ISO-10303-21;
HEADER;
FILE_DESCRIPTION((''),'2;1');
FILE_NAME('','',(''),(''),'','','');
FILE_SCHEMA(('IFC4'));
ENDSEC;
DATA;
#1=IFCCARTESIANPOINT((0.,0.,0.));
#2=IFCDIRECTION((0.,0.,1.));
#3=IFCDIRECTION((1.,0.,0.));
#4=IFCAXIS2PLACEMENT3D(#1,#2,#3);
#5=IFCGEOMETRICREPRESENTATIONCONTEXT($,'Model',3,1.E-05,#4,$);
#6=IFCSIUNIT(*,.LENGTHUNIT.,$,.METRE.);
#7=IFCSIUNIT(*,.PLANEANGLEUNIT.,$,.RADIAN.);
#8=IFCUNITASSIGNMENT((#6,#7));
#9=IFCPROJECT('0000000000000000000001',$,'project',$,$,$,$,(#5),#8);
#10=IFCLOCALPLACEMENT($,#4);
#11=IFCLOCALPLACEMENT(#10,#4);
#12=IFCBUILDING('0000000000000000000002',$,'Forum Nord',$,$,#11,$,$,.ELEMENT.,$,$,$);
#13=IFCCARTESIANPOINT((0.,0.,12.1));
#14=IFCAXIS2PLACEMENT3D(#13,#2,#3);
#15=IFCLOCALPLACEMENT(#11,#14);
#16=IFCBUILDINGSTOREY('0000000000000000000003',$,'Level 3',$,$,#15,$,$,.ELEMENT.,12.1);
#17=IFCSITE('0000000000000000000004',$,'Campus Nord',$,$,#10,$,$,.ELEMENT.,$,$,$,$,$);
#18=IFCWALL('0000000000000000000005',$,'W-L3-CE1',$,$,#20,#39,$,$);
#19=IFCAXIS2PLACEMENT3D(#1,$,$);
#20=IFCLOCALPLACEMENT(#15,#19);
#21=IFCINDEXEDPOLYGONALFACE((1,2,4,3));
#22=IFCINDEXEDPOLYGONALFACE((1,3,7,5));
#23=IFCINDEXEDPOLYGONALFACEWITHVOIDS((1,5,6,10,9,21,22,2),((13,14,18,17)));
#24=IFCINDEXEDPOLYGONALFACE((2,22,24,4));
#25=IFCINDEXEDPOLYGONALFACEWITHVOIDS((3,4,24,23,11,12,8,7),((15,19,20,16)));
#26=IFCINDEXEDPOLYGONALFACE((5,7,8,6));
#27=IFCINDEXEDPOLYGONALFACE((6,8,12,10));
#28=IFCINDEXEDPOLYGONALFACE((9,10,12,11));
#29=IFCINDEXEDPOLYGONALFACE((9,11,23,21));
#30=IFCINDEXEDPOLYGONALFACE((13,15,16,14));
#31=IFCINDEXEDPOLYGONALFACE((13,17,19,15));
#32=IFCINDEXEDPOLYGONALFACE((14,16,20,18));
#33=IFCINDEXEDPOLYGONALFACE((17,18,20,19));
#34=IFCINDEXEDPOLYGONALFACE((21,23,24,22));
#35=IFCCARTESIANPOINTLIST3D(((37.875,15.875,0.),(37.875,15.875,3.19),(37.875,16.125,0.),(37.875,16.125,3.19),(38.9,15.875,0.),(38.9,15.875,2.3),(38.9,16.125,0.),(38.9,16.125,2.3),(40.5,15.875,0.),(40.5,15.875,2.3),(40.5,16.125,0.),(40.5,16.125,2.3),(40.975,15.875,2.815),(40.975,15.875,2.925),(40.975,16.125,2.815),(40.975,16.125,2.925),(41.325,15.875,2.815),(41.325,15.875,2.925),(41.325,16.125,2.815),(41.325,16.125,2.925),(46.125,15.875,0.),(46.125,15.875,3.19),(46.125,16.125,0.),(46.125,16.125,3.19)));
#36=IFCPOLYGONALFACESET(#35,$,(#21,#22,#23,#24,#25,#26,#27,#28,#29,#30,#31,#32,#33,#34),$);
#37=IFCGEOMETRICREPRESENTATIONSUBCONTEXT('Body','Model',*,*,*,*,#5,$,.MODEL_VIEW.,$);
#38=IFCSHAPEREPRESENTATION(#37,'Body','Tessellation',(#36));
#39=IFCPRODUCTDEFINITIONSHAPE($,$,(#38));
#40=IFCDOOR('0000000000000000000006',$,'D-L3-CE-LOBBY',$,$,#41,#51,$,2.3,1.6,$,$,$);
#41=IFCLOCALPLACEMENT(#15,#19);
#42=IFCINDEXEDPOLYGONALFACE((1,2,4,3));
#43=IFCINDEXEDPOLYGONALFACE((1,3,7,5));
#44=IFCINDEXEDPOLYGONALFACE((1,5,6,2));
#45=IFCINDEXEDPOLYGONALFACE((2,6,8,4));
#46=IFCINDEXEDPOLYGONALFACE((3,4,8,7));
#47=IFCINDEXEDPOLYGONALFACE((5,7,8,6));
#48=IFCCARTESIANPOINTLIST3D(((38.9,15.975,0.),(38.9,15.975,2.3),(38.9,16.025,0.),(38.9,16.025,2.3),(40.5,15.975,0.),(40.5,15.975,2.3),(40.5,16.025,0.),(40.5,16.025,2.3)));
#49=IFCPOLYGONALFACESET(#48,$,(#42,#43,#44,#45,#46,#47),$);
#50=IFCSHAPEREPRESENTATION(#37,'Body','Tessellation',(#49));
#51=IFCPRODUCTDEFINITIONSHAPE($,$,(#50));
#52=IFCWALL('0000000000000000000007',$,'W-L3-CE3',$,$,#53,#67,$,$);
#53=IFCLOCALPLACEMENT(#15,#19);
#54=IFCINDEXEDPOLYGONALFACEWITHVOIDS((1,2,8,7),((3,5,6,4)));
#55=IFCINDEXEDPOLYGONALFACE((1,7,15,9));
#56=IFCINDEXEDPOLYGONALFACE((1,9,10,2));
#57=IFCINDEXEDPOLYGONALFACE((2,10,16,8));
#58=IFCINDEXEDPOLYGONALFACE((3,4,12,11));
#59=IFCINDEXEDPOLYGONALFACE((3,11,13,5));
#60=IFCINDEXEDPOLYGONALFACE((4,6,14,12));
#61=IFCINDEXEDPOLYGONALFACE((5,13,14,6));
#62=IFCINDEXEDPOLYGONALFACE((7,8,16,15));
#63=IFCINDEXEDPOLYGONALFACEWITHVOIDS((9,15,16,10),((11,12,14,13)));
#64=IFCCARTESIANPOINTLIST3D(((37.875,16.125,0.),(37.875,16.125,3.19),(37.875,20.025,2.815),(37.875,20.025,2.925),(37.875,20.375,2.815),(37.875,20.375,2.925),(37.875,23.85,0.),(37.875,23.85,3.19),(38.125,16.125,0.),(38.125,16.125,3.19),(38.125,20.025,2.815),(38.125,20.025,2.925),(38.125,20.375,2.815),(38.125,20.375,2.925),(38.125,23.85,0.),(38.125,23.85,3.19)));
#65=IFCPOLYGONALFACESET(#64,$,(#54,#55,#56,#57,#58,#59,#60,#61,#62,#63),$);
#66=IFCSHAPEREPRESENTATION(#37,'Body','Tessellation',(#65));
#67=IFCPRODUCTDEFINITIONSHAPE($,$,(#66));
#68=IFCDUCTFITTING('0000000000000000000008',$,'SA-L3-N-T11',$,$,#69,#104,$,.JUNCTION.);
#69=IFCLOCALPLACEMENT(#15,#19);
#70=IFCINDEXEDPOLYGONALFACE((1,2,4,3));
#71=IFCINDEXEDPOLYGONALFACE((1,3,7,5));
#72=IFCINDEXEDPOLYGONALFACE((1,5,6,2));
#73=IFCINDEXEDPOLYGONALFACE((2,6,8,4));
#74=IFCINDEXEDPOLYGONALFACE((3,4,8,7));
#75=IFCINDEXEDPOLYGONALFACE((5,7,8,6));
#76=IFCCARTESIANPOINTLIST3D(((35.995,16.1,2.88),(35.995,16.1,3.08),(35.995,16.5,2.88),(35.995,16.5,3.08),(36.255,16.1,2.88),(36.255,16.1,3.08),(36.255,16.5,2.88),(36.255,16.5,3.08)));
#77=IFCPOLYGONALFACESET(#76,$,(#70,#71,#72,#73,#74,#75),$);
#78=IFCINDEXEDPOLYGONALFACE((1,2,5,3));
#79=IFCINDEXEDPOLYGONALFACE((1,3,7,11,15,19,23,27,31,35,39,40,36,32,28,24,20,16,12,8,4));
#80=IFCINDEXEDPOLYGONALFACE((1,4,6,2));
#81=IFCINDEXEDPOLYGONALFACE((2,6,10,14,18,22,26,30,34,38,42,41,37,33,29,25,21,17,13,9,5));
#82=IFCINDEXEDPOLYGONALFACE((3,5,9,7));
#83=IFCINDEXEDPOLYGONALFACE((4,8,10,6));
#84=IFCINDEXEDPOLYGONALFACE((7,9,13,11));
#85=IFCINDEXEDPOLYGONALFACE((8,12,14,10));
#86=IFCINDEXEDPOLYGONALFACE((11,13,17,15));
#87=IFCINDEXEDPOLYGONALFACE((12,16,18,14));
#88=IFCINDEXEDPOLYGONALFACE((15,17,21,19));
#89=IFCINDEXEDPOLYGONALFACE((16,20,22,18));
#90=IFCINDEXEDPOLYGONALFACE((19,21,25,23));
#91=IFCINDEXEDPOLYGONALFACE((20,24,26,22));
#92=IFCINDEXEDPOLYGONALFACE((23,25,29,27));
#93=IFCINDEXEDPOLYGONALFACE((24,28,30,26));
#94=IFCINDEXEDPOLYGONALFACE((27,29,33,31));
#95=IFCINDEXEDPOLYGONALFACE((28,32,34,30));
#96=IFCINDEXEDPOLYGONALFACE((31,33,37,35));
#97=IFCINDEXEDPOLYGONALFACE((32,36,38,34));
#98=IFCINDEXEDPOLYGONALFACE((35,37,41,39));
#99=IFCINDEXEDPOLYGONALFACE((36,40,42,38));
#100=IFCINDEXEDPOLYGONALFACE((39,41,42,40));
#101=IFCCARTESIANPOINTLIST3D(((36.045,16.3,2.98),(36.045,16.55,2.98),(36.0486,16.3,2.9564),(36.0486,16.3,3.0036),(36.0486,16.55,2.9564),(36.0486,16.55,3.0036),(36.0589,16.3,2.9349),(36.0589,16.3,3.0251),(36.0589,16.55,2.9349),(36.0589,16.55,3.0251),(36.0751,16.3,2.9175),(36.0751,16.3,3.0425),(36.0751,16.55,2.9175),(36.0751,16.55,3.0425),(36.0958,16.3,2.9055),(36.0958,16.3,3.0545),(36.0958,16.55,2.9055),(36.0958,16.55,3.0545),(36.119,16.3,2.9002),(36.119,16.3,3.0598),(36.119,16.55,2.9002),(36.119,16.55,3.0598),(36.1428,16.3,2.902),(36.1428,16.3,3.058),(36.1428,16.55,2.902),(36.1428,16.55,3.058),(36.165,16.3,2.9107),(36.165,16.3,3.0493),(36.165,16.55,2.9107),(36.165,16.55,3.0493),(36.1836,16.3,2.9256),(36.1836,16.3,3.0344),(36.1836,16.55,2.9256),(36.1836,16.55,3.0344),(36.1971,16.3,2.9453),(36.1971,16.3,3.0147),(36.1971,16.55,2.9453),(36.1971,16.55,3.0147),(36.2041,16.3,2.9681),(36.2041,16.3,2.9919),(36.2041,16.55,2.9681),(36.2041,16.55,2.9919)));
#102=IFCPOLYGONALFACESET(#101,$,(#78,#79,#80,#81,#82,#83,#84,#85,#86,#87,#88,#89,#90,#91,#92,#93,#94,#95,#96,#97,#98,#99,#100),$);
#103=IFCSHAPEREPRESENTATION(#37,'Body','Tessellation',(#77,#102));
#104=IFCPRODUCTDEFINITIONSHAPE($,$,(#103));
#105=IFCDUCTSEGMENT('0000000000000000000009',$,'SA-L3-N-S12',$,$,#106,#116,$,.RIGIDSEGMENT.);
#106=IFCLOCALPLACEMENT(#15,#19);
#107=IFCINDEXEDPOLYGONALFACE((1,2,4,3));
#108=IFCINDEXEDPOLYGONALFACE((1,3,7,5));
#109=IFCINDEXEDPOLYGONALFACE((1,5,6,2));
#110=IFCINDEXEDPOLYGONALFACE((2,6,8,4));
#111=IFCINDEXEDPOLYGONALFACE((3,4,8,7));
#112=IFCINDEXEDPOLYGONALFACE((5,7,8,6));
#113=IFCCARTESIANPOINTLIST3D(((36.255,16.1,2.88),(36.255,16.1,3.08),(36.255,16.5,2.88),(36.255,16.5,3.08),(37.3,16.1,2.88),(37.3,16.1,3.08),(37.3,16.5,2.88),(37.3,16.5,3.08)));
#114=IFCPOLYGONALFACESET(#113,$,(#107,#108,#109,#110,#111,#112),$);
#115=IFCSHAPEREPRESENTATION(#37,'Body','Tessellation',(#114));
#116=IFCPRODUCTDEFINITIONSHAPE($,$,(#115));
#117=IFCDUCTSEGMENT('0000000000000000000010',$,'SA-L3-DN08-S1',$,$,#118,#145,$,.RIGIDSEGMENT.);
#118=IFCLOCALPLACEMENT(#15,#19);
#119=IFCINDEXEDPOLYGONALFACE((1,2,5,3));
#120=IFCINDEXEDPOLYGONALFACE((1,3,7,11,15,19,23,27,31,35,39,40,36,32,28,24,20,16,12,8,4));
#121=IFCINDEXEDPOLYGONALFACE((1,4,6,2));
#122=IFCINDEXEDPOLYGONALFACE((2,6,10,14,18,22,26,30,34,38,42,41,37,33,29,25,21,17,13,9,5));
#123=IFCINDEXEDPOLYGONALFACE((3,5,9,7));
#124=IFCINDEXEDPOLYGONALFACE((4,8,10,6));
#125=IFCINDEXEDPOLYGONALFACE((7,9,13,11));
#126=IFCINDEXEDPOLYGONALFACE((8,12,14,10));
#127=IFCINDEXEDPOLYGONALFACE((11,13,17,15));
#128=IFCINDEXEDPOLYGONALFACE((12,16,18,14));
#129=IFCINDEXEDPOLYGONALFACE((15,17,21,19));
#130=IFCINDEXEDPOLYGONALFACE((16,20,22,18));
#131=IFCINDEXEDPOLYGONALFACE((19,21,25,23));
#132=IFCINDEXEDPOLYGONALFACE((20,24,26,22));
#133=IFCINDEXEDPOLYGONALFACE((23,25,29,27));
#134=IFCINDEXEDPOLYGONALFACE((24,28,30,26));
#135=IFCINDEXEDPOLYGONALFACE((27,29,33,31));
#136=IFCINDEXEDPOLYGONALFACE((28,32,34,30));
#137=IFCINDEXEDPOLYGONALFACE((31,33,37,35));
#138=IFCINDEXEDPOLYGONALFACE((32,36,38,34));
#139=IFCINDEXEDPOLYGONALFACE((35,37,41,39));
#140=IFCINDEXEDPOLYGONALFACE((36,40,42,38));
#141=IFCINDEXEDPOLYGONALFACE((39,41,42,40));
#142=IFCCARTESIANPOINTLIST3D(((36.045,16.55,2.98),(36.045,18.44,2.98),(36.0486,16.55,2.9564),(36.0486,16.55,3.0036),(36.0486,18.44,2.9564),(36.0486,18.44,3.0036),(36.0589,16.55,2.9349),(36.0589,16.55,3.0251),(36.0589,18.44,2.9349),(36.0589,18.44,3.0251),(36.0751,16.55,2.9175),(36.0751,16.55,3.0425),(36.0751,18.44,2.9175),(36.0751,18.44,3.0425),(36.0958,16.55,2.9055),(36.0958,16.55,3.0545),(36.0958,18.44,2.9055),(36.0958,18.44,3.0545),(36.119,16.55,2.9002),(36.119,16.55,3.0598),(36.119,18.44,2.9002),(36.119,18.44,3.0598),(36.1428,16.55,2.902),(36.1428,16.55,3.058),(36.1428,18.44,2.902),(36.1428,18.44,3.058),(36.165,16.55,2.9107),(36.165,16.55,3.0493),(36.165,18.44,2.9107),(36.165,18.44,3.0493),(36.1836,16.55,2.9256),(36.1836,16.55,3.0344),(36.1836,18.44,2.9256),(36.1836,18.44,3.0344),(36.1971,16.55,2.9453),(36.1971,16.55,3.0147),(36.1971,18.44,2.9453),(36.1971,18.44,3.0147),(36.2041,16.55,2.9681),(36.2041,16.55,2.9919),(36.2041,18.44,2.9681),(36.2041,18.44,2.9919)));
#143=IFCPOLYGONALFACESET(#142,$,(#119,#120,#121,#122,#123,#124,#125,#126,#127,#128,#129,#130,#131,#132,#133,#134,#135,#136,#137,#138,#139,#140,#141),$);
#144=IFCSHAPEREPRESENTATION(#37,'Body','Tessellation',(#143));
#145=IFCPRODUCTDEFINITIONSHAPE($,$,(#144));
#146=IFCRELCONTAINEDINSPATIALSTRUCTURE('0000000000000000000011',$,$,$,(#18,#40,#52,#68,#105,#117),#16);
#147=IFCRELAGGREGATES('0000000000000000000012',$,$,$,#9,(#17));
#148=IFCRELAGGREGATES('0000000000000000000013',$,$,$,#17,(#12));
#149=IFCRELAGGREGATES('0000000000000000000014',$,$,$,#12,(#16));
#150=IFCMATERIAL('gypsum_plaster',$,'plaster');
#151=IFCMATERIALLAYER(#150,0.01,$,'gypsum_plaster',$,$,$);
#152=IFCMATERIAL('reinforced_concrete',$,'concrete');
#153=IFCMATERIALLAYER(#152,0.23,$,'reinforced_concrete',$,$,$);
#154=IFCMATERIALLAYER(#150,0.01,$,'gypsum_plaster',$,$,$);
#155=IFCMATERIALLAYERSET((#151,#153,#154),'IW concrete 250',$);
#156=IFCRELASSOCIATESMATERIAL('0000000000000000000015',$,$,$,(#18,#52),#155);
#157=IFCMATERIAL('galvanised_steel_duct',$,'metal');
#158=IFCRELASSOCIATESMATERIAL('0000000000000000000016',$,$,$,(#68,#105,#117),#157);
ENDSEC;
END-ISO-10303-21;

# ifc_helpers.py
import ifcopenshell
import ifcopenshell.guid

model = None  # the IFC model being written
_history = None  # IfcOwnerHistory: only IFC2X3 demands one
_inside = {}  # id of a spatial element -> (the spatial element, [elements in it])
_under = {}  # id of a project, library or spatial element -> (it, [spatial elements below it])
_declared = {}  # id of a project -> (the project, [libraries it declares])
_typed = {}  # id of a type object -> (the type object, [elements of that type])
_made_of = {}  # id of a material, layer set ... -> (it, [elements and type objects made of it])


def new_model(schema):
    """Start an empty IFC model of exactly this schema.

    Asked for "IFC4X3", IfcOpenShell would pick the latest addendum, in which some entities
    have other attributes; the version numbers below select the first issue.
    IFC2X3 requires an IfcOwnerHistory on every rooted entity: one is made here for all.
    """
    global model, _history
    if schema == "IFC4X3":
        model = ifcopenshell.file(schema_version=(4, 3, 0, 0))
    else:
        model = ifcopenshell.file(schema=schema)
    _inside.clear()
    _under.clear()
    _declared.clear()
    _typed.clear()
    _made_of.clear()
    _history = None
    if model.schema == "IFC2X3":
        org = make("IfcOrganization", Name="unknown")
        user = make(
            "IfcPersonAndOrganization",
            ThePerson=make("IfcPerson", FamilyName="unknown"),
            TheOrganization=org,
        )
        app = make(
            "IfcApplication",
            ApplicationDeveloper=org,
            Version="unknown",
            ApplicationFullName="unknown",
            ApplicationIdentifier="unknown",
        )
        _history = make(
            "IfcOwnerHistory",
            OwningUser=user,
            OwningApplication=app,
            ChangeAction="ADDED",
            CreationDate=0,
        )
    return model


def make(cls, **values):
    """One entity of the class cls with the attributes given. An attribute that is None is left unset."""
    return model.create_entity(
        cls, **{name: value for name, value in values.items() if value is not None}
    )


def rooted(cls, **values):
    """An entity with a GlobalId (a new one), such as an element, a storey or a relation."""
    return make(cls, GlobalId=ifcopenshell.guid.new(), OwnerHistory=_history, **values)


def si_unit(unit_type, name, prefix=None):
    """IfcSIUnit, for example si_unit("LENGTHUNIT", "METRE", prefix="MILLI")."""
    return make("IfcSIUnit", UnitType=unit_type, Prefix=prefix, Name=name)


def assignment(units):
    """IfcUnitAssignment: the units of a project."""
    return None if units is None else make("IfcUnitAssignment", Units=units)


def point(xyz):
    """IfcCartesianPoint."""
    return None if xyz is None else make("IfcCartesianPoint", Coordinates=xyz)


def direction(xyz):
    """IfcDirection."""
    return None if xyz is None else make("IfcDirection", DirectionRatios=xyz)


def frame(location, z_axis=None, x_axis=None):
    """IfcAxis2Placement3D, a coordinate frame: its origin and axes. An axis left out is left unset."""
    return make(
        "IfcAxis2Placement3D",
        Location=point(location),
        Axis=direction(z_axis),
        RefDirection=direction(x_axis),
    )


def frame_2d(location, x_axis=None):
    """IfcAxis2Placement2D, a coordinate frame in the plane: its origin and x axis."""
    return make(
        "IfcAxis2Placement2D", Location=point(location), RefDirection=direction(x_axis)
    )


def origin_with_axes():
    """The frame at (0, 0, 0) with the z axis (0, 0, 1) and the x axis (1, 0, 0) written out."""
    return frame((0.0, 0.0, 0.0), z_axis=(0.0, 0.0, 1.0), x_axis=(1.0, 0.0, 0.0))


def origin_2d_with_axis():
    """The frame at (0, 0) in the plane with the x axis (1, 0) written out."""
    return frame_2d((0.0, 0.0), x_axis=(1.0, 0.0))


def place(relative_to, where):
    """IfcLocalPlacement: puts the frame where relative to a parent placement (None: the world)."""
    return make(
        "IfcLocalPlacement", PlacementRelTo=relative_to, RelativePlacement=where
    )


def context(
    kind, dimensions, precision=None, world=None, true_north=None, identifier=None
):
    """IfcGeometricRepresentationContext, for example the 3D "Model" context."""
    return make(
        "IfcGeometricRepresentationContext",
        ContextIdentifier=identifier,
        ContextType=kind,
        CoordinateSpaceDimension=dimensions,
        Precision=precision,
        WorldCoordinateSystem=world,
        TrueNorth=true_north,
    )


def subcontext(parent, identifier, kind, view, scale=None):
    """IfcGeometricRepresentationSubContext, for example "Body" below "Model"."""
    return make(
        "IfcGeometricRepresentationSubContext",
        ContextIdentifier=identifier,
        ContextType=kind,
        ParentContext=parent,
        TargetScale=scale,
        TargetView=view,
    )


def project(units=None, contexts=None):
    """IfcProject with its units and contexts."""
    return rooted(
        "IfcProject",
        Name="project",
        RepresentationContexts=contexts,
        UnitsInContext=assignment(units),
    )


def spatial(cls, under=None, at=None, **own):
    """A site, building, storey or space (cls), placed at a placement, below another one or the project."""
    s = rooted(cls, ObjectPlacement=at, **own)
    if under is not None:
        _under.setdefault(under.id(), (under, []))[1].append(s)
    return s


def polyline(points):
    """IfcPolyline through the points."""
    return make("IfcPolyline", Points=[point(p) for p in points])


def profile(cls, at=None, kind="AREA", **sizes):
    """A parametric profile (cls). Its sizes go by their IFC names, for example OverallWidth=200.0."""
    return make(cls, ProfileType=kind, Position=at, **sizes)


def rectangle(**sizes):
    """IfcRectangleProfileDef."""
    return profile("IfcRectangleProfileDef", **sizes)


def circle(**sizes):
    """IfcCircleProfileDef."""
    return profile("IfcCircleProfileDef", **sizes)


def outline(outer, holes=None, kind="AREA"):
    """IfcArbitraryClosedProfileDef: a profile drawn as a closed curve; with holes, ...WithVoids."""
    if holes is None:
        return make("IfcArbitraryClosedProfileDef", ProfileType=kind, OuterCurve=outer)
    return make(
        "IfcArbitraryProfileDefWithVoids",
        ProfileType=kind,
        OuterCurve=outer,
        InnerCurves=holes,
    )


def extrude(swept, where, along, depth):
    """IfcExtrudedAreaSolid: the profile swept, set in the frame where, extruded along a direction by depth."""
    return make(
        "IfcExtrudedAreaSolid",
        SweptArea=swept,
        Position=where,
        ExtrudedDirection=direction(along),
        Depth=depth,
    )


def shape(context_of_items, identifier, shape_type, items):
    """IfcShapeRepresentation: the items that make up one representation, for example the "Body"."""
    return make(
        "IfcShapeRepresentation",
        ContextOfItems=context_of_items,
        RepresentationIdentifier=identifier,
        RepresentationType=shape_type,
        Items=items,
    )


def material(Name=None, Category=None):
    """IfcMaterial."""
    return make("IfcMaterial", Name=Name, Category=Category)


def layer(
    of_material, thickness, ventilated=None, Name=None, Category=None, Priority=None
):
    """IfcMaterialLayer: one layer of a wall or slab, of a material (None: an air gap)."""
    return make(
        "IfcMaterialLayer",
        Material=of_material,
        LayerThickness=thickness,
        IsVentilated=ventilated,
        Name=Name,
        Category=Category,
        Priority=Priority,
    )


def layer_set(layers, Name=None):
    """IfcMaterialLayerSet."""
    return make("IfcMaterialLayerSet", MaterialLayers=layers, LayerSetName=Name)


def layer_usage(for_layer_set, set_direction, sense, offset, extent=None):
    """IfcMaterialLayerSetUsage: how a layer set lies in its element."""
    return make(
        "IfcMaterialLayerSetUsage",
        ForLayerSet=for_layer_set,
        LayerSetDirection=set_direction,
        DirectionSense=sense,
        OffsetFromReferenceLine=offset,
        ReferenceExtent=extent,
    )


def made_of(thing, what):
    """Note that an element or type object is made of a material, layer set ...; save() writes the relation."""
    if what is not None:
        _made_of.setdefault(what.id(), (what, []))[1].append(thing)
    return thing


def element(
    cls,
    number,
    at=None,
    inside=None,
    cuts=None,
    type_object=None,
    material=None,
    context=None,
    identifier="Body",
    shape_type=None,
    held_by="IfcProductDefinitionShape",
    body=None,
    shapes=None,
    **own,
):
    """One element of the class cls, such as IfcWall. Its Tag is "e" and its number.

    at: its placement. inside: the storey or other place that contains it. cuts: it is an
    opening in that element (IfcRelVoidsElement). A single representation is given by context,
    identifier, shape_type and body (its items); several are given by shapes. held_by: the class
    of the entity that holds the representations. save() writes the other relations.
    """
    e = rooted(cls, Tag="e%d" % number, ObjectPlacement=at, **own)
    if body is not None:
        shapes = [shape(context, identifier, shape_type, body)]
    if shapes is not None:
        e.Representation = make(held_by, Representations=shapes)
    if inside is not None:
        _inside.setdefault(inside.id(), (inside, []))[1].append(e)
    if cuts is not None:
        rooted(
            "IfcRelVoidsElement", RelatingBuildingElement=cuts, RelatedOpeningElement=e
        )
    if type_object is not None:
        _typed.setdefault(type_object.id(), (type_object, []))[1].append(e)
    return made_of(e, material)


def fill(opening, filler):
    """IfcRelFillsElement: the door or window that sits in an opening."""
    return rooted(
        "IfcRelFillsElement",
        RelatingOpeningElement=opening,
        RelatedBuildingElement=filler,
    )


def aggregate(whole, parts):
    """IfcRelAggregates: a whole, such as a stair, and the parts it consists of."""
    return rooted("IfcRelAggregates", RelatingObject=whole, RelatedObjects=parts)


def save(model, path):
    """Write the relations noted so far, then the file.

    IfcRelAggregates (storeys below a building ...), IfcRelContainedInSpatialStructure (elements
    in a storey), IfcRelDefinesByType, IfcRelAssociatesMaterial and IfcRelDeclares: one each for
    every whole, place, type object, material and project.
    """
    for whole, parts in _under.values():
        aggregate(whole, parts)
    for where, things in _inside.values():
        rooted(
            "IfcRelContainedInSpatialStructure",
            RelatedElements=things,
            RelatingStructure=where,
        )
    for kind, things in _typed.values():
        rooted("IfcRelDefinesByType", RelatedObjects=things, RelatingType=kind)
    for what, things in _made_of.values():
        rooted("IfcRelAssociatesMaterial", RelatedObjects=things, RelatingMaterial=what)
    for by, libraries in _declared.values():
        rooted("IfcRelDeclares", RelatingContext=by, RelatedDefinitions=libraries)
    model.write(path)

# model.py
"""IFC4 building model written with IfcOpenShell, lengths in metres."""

from ifc_helpers import new_model, si_unit, frame, frame_2d, origin_with_axes, origin_2d_with_axis, place, context, subcontext, project, spatial, polyline, rectangle, circle, outline, extrude, material, layer, layer_set, layer_usage, element, fill, save


model = new_model("IFC4")

# Units and contexts
model_context = context("Model", 3, precision=1e-05, world=origin_with_axes())
body_context = subcontext(model_context, "Body", "Model", "MODEL_VIEW")
ifc_project = project(units=[si_unit("LENGTHUNIT", "METRE"), si_unit("PLANEANGLEUNIT", "RADIAN")], contexts=[model_context])

# Site, building, storey
site_placement = place(None, origin_with_axes())
site = spatial("IfcSite", under=ifc_project, at=site_placement, Name="Campus Nord", CompositionType="ELEMENT")
building_placement = place(site_placement, origin_with_axes())
building = spatial("IfcBuilding", under=site, at=building_placement, Name="Forum Nord", CompositionType="ELEMENT")
storey_placement = place(building_placement, frame((0.0, 0.0, 12.1), z_axis=(0.0, 0.0, 1.0), x_axis=(1.0, 0.0, 0.0)))
storey = spatial("IfcBuildingStorey", under=building, at=storey_placement, Name="Level 3", CompositionType="ELEMENT", Elevation=12.1)

# Wall, openings, door
ifc_material_1 = material(Name="gypsum_plaster", Category="plaster")
ifc_layer_1 = layer(ifc_material_1, 0.01, Name="gypsum_plaster")
ifc_material_2 = material(Name="reinforced_concrete", Category="concrete")
ifc_layer_2 = layer(ifc_material_2, 0.23, Name="reinforced_concrete")
ifc_layer_3 = layer(ifc_material_1, 0.01, Name="gypsum_plaster")
ifc_layer_set_1 = layer_set([ifc_layer_1, ifc_layer_2, ifc_layer_3], Name="IW concrete 250")
ifc_layer_usage_1 = layer_usage(ifc_layer_set_1, "AXIS2", "POSITIVE", -0.125)
wall_1_placement = place(storey_placement, frame((37.875, 16.0, 0.0), z_axis=(0.0, 0.0, 1.0), x_axis=(1.0, 0.0, 0.0)))
wall_1 = element("IfcWall", 1, at=wall_1_placement, inside=storey, material=ifc_layer_usage_1, Name="W-L3-CE1", context=body_context, shape_type="SweptSolid", body=[
    extrude(rectangle(XDim=8.25, YDim=0.25, at=frame_2d((4.125, 0.0), x_axis=(1.0, 0.0))), origin_with_axes(), (0.0, 0.0, 1.0), 3.19),
])
opening_1_placement = place(storey_placement, frame((0.0, 0.0, 2.815), z_axis=(0.0, 0.0, 1.0), x_axis=(1.0, 0.0, 0.0)))
element("IfcOpeningElement", 2, at=opening_1_placement, cuts=wall_1, context=body_context, shape_type="SweptSolid", body=[
    extrude(outline(polyline([(40.975, 15.825), (41.325, 15.825), (41.325, 16.175), (40.975, 16.175), (40.975, 15.825)])), origin_with_axes(), (0.0, 0.0, 1.0), 0.11),
])
opening_2_placement = place(storey_placement, frame((37.875, 16.0, 0.0), z_axis=(0.0, 0.0, 1.0), x_axis=(1.0, 0.0, 0.0)))
opening_2 = element("IfcOpeningElement", 3, at=opening_2_placement, cuts=wall_1, context=body_context, shape_type="SweptSolid", body=[
    extrude(rectangle(XDim=1.6, YDim=0.25, at=frame_2d((1.825, 0.0), x_axis=(1.0, 0.0))), origin_with_axes(), (0.0, 0.0, 1.0), 2.3),
])
door_placement = place(storey_placement, frame((37.875, 16.0, 0.0), z_axis=(0.0, 0.0, 1.0), x_axis=(1.0, 0.0, 0.0)))
door = element("IfcDoor", 4, at=door_placement, inside=storey, Name="D-L3-CE-LOBBY", OverallHeight=2.3, OverallWidth=1.6, context=body_context, shape_type="SweptSolid", body=[
    extrude(rectangle(XDim=1.6, YDim=0.05, at=frame_2d((1.825, 0.0), x_axis=(1.0, 0.0))), origin_with_axes(), (0.0, 0.0, 1.0), 2.3),
])
fill(opening_2, door)

# Wall, opening
wall_2_placement = place(storey_placement, frame((38.0, 16.125, 0.0), z_axis=(0.0, 0.0, 1.0), x_axis=(0.0, 1.0, 0.0)))
wall_2 = element("IfcWall", 5, at=wall_2_placement, inside=storey, material=ifc_layer_usage_1, Name="W-L3-CE3", context=body_context, shape_type="SweptSolid", body=[
    extrude(outline(polyline([(0.0, -0.125), (7.725, -0.125), (7.725, 0.125), (0.0, 0.125), (0.0, -0.125)])), origin_with_axes(), (0.0, 0.0, 1.0), 3.19),
])
opening_3_placement = place(storey_placement, frame((0.0, 0.0, 2.815), z_axis=(0.0, 0.0, 1.0), x_axis=(1.0, 0.0, 0.0)))
element("IfcOpeningElement", 6, at=opening_3_placement, cuts=wall_2, context=body_context, shape_type="SweptSolid", body=[
    extrude(outline(polyline([(38.175, 20.025), (38.175, 20.375), (37.825, 20.375), (37.825, 20.025), (38.175, 20.025)])), origin_with_axes(), (0.0, 0.0, 1.0), 0.11),
])

# Duct fitting
ifc_material_3 = material(Name="galvanised_steel_duct", Category="metal")
duct_fitting_placement = place(storey_placement, frame((35.995, 16.3, 2.98), z_axis=(1.0, 0.0, 0.0), x_axis=(0.0, 1.0, 0.0)))
element("IfcDuctFitting", 7, at=duct_fitting_placement, inside=storey, material=ifc_material_3, Name="SA-L3-N-T11", PredefinedType="JUNCTION", context=body_context, shape_type="SweptSolid", body=[
    extrude(rectangle(XDim=0.4, YDim=0.2, at=origin_2d_with_axis()), origin_with_axes(), (0.0, 0.0, 1.0), 0.26),
    extrude(circle(Radius=0.08, at=origin_2d_with_axis()), frame((0.0, 0.0, 0.13), z_axis=(1.0, 0.0, 0.0), x_axis=(0.0, 0.0, -1.0)), (0.0, 0.0, 1.0), 0.25),
])

# Duct segments
duct_segment_1_placement = place(storey_placement, frame((36.255, 16.3, 2.98), z_axis=(1.0, 0.0, 0.0), x_axis=(0.0, 1.0, 0.0)))
element("IfcDuctSegment", 8, at=duct_segment_1_placement, inside=storey, material=ifc_material_3, Name="SA-L3-N-S12", PredefinedType="RIGIDSEGMENT", context=body_context, shape_type="SweptSolid", body=[
    extrude(rectangle(XDim=0.4, YDim=0.2, at=origin_2d_with_axis()), origin_with_axes(), (0.0, 0.0, 1.0), 1.045),
])
duct_segment_2_placement = place(storey_placement, frame((36.125, 16.55, 2.98), z_axis=(0.0, 1.0, 0.0), x_axis=(-1.0, 0.0, 0.0)))
element("IfcDuctSegment", 9, at=duct_segment_2_placement, inside=storey, material=ifc_material_3, Name="SA-L3-DN08-S1", PredefinedType="RIGIDSEGMENT", context=body_context, shape_type="SweptSolid", body=[
    extrude(circle(Radius=0.08, at=origin_2d_with_axis()), origin_with_axes(), (0.0, 0.0, 1.0), 1.89),
])

save(model, "model.ifc")
